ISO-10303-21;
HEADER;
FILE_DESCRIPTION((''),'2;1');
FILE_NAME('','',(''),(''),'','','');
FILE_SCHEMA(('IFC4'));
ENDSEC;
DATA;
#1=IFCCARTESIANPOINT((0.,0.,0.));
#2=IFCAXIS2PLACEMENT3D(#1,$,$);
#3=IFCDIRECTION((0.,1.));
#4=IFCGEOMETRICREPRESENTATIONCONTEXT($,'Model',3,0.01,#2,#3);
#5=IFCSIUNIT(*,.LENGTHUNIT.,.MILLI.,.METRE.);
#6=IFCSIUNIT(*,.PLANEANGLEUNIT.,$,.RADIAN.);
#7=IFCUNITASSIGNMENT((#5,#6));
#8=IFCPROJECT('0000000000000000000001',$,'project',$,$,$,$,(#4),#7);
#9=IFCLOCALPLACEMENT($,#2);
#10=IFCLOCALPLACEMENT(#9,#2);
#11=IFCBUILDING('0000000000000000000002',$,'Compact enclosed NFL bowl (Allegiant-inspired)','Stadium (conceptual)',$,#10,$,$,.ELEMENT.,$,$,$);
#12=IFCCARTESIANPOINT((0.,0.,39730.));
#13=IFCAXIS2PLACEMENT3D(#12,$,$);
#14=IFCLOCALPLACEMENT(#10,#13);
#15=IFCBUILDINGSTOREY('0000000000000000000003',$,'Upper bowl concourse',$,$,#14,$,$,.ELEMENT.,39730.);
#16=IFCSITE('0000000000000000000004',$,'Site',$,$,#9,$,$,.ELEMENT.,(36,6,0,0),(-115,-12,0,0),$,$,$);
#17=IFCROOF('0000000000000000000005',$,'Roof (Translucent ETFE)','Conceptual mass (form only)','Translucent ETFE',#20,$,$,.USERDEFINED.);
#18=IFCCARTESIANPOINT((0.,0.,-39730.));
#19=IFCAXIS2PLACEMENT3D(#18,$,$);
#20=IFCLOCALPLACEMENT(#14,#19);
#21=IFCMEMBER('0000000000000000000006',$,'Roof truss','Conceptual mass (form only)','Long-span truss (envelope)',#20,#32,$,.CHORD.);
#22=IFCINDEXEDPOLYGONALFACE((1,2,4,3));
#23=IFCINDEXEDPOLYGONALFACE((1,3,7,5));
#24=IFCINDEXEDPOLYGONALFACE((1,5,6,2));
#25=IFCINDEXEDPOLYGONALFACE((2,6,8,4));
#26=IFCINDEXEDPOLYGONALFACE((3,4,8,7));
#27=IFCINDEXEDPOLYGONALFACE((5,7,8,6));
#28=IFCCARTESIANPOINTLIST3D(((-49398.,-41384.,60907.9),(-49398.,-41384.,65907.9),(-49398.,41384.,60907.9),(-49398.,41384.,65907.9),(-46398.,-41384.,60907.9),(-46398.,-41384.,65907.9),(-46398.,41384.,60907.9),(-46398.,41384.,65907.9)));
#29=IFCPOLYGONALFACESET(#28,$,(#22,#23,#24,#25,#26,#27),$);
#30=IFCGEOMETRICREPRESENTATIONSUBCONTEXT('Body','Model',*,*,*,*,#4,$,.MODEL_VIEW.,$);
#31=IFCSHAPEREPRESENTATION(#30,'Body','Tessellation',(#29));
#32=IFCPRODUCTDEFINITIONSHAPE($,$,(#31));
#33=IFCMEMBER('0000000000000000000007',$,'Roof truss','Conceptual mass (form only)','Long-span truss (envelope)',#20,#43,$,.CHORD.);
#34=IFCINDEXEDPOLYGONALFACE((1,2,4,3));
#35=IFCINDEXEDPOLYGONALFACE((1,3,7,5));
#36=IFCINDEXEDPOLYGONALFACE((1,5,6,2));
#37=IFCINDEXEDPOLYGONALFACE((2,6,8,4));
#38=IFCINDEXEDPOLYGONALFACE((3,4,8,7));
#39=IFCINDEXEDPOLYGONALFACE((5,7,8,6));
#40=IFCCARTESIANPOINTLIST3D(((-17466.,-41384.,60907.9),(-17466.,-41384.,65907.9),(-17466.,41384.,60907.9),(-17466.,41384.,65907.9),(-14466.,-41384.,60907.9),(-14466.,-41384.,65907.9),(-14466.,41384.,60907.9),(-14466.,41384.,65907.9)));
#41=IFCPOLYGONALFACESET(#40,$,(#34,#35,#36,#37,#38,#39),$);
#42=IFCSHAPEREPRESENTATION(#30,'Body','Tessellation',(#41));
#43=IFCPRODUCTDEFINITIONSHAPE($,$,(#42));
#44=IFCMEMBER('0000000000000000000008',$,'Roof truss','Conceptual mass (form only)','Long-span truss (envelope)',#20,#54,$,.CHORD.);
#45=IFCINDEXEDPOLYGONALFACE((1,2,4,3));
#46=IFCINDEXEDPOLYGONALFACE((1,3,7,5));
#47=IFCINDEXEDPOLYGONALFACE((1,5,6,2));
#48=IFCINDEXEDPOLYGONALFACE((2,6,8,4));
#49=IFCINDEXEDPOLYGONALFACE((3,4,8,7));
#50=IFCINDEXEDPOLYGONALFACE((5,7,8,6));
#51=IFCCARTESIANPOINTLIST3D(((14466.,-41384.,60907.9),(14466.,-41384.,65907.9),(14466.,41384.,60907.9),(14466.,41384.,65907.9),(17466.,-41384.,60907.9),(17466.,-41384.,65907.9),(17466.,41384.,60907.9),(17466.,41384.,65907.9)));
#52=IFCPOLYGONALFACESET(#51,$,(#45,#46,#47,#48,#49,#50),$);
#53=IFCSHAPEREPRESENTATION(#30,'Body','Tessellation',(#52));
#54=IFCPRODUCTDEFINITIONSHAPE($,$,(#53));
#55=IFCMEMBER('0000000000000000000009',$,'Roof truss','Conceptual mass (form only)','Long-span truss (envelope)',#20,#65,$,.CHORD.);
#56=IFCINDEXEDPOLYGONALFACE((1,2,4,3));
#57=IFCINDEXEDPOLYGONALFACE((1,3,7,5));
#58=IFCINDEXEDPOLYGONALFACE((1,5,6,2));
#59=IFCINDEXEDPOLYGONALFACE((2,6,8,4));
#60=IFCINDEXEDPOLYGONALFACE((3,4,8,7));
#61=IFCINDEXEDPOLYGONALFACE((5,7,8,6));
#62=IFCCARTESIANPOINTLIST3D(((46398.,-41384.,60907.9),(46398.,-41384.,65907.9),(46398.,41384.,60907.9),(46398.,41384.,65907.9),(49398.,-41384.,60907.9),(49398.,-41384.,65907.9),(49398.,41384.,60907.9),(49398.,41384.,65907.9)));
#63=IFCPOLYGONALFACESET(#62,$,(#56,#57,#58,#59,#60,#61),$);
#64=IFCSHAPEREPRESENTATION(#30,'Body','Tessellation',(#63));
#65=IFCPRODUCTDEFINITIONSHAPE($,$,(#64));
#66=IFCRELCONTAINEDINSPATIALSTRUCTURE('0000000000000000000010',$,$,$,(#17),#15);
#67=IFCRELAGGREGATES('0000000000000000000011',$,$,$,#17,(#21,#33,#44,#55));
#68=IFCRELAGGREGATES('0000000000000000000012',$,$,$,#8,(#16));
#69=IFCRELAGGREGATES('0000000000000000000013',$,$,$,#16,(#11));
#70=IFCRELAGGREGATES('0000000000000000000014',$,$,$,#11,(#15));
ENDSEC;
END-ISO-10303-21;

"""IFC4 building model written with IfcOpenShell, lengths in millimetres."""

from ifc_helpers import new_model, si_unit, direction, frame, origin, place, context, subcontext, project, spatial, rectangle, extrude, element, aggregate, save


model = new_model("IFC4")

# Units and contexts
model_context = context("Model", 3, precision=0.01, world=origin(), true_north=direction((0.0, 1.0)))
body_context = subcontext(model_context, "Body", "Model", "MODEL_VIEW")
ifc_project = project(units=[si_unit("LENGTHUNIT", "METRE", prefix="MILLI"), si_unit("PLANEANGLEUNIT", "RADIAN")], contexts=[model_context])

# Site, building, storey
site_placement = place(None, origin())
site = spatial("IfcSite", under=ifc_project, at=site_placement, Name="Site", CompositionType="ELEMENT", RefLatitude=(36, 6, 0, 0), RefLongitude=(-115, -12, 0, 0))
building_placement = place(site_placement, origin())
building = spatial("IfcBuilding", under=site, at=building_placement, Name="Compact enclosed NFL bowl (Allegiant-inspired)", Description="Stadium (conceptual)", CompositionType="ELEMENT")
storey_placement = place(building_placement, frame((0.0, 0.0, 39730.0)))
storey = spatial("IfcBuildingStorey", under=building, at=storey_placement, Name="Upper bowl concourse", CompositionType="ELEMENT", Elevation=39730.0)

# Roof, members
placement = place(storey_placement, frame((0.0, 0.0, -39730.0)))
roof = element("IfcRoof", 1, at=placement, inside=storey, Name="Roof (Translucent ETFE)", Description="Conceptual mass (form only)", ObjectType="Translucent ETFE", PredefinedType="USERDEFINED")
member_1 = element("IfcMember", 2, at=placement, Name="Roof truss", Description="Conceptual mass (form only)", ObjectType="Long-span truss (envelope)", PredefinedType="CHORD", context=body_context, shape_type="SweptSolid", body=[
    extrude(rectangle(XDim=3000.0, YDim=82768.0), frame((-47898.0, 0.0, 60907.9)), (0.0, 0.0, 1.0), 5000.0),
])
member_2 = element("IfcMember", 3, at=placement, Name="Roof truss", Description="Conceptual mass (form only)", ObjectType="Long-span truss (envelope)", PredefinedType="CHORD", context=body_context, shape_type="SweptSolid", body=[
    extrude(rectangle(XDim=3000.0, YDim=82768.0), frame((-15966.0, 0.0, 60907.9)), (0.0, 0.0, 1.0), 5000.0),
])
member_3 = element("IfcMember", 4, at=placement, Name="Roof truss", Description="Conceptual mass (form only)", ObjectType="Long-span truss (envelope)", PredefinedType="CHORD", context=body_context, shape_type="SweptSolid", body=[
    extrude(rectangle(XDim=3000.0, YDim=82768.0), frame((15966.0, 0.0, 60907.9)), (0.0, 0.0, 1.0), 5000.0),
])
member_4 = element("IfcMember", 5, at=placement, Name="Roof truss", Description="Conceptual mass (form only)", ObjectType="Long-span truss (envelope)", PredefinedType="CHORD", context=body_context, shape_type="SweptSolid", body=[
    extrude(rectangle(XDim=3000.0, YDim=82768.0), frame((47898.0, 0.0, 60907.9)), (0.0, 0.0, 1.0), 5000.0),
])
aggregate(roof, [member_1, member_2, member_3, member_4])

save(model, "model.ifc")
